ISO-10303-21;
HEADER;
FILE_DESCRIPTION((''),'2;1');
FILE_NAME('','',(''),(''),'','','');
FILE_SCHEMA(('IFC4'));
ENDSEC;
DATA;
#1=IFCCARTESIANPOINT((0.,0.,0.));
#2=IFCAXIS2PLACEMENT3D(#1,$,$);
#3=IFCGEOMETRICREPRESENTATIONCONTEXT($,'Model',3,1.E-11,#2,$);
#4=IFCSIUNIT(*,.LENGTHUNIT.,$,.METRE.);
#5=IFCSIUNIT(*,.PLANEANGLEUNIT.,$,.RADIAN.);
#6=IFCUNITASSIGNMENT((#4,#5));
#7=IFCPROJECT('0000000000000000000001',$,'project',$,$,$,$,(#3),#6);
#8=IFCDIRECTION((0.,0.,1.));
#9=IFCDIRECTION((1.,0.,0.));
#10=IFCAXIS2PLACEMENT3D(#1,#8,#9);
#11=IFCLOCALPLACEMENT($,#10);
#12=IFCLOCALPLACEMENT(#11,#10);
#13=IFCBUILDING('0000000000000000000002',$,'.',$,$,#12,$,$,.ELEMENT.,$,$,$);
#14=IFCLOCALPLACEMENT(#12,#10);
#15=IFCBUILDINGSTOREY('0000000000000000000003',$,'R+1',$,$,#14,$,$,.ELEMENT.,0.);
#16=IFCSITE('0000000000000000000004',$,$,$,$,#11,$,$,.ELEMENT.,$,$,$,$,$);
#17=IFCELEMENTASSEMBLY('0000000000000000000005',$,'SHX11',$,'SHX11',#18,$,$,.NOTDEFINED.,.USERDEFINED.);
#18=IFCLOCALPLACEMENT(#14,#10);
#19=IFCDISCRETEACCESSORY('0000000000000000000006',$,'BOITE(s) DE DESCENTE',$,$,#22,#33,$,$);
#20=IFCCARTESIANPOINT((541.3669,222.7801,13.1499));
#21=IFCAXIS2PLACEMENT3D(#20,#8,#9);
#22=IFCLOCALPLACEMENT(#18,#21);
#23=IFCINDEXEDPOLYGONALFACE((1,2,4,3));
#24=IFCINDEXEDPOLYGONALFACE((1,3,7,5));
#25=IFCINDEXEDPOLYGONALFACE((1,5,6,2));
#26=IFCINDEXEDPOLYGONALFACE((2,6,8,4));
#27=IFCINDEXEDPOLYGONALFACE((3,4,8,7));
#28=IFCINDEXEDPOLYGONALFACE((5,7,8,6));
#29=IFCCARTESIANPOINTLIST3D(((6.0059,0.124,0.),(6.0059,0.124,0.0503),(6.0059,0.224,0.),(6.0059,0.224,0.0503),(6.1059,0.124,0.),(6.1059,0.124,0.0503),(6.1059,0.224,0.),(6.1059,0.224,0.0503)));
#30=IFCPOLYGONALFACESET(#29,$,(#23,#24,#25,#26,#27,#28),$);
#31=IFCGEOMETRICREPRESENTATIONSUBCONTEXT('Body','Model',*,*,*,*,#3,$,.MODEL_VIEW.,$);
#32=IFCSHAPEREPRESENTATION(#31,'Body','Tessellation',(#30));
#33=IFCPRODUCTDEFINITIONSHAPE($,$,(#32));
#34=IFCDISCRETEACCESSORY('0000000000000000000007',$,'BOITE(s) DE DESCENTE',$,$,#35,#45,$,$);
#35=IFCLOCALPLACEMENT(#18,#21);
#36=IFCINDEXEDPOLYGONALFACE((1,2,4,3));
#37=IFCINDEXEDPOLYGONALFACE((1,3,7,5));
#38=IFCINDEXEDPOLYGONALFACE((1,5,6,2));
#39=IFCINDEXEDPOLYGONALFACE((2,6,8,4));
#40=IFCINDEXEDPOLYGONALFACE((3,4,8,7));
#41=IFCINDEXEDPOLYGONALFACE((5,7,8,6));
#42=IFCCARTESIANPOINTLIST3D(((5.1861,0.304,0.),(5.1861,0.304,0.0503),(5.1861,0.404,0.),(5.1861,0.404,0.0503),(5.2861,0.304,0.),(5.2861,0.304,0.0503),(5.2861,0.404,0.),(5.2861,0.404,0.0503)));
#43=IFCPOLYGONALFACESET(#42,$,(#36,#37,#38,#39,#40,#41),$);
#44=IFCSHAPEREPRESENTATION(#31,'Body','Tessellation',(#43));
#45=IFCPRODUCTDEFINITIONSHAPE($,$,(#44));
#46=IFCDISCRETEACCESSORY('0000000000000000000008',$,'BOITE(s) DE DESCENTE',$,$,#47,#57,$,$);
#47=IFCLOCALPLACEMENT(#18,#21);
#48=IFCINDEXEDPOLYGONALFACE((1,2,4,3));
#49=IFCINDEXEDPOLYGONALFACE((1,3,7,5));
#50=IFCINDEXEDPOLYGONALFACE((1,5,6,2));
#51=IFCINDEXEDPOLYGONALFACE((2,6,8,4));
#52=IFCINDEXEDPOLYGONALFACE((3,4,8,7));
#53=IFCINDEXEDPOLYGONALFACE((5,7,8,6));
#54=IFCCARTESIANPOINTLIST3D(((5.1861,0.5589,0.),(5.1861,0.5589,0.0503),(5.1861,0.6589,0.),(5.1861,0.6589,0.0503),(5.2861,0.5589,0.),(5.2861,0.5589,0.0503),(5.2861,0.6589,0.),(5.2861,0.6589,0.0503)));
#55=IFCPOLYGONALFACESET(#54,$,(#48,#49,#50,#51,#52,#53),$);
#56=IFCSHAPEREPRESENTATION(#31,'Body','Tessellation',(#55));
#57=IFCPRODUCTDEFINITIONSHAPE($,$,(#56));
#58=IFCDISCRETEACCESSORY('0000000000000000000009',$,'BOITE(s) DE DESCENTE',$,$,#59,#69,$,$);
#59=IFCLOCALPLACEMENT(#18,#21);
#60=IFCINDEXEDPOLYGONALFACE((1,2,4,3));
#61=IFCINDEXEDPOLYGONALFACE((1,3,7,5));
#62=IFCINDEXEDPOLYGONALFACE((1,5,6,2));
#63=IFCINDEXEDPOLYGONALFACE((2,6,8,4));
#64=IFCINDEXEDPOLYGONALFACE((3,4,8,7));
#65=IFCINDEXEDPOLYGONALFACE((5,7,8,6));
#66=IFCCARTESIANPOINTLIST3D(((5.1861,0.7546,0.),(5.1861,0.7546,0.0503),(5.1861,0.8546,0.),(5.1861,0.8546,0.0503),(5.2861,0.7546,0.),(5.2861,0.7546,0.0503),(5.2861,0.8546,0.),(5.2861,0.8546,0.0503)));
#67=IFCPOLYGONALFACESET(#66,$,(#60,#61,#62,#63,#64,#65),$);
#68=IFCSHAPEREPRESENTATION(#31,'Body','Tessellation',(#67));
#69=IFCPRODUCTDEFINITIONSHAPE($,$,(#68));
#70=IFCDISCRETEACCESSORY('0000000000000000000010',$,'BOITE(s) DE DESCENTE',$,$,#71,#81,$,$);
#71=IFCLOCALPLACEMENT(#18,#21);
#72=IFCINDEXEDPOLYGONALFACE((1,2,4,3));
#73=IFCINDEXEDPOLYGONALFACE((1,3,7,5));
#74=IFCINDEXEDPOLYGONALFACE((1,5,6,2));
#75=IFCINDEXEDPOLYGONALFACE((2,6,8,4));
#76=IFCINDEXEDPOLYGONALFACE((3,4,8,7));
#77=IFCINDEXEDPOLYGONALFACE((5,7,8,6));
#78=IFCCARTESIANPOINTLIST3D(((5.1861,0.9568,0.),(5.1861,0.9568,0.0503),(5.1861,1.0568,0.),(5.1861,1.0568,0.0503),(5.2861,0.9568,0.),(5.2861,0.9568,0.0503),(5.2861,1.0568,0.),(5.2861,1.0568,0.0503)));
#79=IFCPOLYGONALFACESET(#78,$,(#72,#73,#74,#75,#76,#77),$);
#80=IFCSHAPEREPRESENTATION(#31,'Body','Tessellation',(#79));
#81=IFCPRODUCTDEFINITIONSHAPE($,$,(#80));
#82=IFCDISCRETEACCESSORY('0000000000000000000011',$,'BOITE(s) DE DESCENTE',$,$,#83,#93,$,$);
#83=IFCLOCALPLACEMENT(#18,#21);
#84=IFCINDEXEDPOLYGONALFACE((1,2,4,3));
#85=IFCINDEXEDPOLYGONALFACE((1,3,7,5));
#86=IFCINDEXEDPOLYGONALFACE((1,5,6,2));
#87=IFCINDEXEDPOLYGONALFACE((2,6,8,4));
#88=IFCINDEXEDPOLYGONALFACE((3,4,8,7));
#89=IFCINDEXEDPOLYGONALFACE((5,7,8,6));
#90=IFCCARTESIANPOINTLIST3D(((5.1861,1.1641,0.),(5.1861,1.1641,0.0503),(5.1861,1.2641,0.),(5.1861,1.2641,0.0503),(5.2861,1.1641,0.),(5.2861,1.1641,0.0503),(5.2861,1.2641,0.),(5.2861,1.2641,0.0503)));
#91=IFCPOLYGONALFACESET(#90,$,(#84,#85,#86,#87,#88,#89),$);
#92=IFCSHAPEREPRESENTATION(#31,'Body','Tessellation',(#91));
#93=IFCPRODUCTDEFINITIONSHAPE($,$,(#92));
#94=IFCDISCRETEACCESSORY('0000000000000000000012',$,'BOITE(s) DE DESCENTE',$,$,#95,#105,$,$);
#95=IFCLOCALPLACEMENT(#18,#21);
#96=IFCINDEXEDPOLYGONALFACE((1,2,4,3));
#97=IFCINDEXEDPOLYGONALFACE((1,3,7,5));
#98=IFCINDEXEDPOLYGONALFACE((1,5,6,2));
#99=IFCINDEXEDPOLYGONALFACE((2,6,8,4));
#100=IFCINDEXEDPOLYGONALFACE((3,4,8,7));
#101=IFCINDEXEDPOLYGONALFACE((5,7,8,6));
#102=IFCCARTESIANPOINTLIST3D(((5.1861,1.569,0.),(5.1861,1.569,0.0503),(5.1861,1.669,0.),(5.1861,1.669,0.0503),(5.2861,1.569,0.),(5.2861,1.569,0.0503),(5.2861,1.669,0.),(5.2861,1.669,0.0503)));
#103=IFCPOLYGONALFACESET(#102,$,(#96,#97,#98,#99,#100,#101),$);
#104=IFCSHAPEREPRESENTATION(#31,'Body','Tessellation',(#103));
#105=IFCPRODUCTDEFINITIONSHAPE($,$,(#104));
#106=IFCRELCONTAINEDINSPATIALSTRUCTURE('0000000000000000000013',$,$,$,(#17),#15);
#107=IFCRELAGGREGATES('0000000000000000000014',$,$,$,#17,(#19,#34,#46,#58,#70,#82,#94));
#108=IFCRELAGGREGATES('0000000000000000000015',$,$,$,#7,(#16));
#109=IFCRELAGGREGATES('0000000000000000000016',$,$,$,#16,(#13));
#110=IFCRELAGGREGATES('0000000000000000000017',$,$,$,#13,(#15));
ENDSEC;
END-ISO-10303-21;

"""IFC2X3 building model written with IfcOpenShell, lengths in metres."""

from ifc_helpers import new_model, si_unit, frame, origin, origin_with_axes, place, context, subcontext, project, spatial, polyline, outline, extrude, element, aggregate, save


model = new_model("IFC2X3")

# Units and contexts
model_context = context("Model", 3, precision=1e-11, world=origin())
body_context = subcontext(model_context, "Body", "Model", "MODEL_VIEW")
ifc_project = project(units=[si_unit("LENGTHUNIT", "METRE"), si_unit("PLANEANGLEUNIT", "RADIAN")], contexts=[model_context])

# Site, building, storey
site_placement = place(None, origin_with_axes())
site = spatial("IfcSite", under=ifc_project, at=site_placement, CompositionType="ELEMENT")
building_placement = place(site_placement, origin_with_axes())
building = spatial("IfcBuilding", under=site, at=building_placement, Name=".", CompositionType="ELEMENT")
storey_placement = place(building_placement, origin_with_axes())
storey = spatial("IfcBuildingStorey", under=building, at=storey_placement, Name="R+1", CompositionType="ELEMENT", Elevation=0.0)

# Element assembly, discrete accessories
assembly_1_placement = place(storey_placement, origin_with_axes())
assembly_1 = element("IfcElementAssembly", 1, at=assembly_1_placement, inside=storey, Name="SHX11", ObjectType="SHX11", AssemblyPlace="NOTDEFINED", PredefinedType="USERDEFINED")
discrete_accessory_1_placement = place(assembly_1_placement, frame((541.3669, 222.7801, 13.1499), z_axis=(0.0, 0.0, 1.0), x_axis=(1.0, 0.0, 0.0)))
discrete_accessory_1 = element("IfcDiscreteAccessory", 2, at=discrete_accessory_1_placement, Name="BOITE(s) DE DESCENTE", context=body_context, shape_type="SweptSolid", body=[
    extrude(outline(polyline([(0.124, -6.0059), (0.124, -6.1059), (0.224, -6.1059), (0.224, -6.0059), (0.124, -6.0059)])), frame((0.0, 0.0, 0.0), z_axis=(0.0, 0.0, 1.0), x_axis=(0.0, 1.0, 0.0)), (0.0, 0.0, 1.0), 0.0503),
])
discrete_accessory_2_placement = place(assembly_1_placement, frame((541.3669, 222.7801, 13.1499), z_axis=(0.0, 0.0, 1.0), x_axis=(1.0, 0.0, 0.0)))
discrete_accessory_2 = element("IfcDiscreteAccessory", 3, at=discrete_accessory_2_placement, Name="BOITE(s) DE DESCENTE", context=body_context, shape_type="SweptSolid", body=[
    extrude(outline(polyline([(0.304, -5.1861), (0.304, -5.2861), (0.404, -5.2861), (0.404, -5.1861), (0.304, -5.1861)])), frame((0.0, 0.0, 0.0), z_axis=(0.0, 0.0, 1.0), x_axis=(0.0, 1.0, 0.0)), (0.0, 0.0, 1.0), 0.0503),
])
discrete_accessory_3_placement = place(assembly_1_placement, frame((541.3669, 222.7801, 13.1499), z_axis=(0.0, 0.0, 1.0), x_axis=(1.0, 0.0, 0.0)))
discrete_accessory_3 = element("IfcDiscreteAccessory", 4, at=discrete_accessory_3_placement, Name="BOITE(s) DE DESCENTE", context=body_context, shape_type="SweptSolid", body=[
    extrude(outline(polyline([(0.5589, -5.1861), (0.5589, -5.2861), (0.6589, -5.2861), (0.6589, -5.1861), (0.5589, -5.1861)])), frame((0.0, 0.0, 0.0), z_axis=(0.0, 0.0, 1.0), x_axis=(0.0, 1.0, 0.0)), (0.0, 0.0, 1.0), 0.0503),
])
discrete_accessory_4_placement = place(assembly_1_placement, frame((541.3669, 222.7801, 13.1499), z_axis=(0.0, 0.0, 1.0), x_axis=(1.0, 0.0, 0.0)))
discrete_accessory_4 = element("IfcDiscreteAccessory", 5, at=discrete_accessory_4_placement, Name="BOITE(s) DE DESCENTE", context=body_context, shape_type="SweptSolid", body=[
    extrude(outline(polyline([(0.7546, -5.1861), (0.7546, -5.2861), (0.8546, -5.2861), (0.8546, -5.1861), (0.7546, -5.1861)])), frame((0.0, 0.0, 0.0), z_axis=(0.0, 0.0, 1.0), x_axis=(0.0, 1.0, 0.0)), (0.0, 0.0, 1.0), 0.0503),
])
discrete_accessory_5_placement = place(assembly_1_placement, frame((541.3669, 222.7801, 13.1499), z_axis=(0.0, 0.0, 1.0), x_axis=(1.0, 0.0, 0.0)))
discrete_accessory_5 = element("IfcDiscreteAccessory", 6, at=discrete_accessory_5_placement, Name="BOITE(s) DE DESCENTE", context=body_context, shape_type="SweptSolid", body=[
    extrude(outline(polyline([(0.9568, -5.1861), (0.9568, -5.2861), (1.0568, -5.2861), (1.0568, -5.1861), (0.9568, -5.1861)])), frame((0.0, 0.0, 0.0), z_axis=(0.0, 0.0, 1.0), x_axis=(0.0, 1.0, 0.0)), (0.0, 0.0, 1.0), 0.0503),
])
discrete_accessory_6_placement = place(assembly_1_placement, frame((541.3669, 222.7801, 13.1499), z_axis=(0.0, 0.0, 1.0), x_axis=(1.0, 0.0, 0.0)))
discrete_accessory_6 = element("IfcDiscreteAccessory", 7, at=discrete_accessory_6_placement, Name="BOITE(s) DE DESCENTE", context=body_context, shape_type="SweptSolid", body=[
    extrude(outline(polyline([(1.1641, -5.1861), (1.1641, -5.2861), (1.2641, -5.2861), (1.2641, -5.1861), (1.1641, -5.1861)])), frame((0.0, 0.0, 0.0), z_axis=(0.0, 0.0, 1.0), x_axis=(0.0, 1.0, 0.0)), (0.0, 0.0, 1.0), 0.0503),
])
discrete_accessory_7_placement = place(assembly_1_placement, frame((541.3669, 222.7801, 13.1499), z_axis=(0.0, 0.0, 1.0), x_axis=(1.0, 0.0, 0.0)))
discrete_accessory_7 = element("IfcDiscreteAccessory", 8, at=discrete_accessory_7_placement, Name="BOITE(s) DE DESCENTE", context=body_context, shape_type="SweptSolid", body=[
    extrude(outline(polyline([(1.569, -5.1861), (1.569, -5.2861), (1.669, -5.2861), (1.669, -5.1861), (1.569, -5.1861)])), frame((0.0, 0.0, 0.0), z_axis=(0.0, 0.0, 1.0), x_axis=(0.0, 1.0, 0.0)), (0.0, 0.0, 1.0), 0.0503),
])
aggregate(assembly_1, [discrete_accessory_1, discrete_accessory_2, discrete_accessory_3, discrete_accessory_4, discrete_accessory_5, discrete_accessory_6, discrete_accessory_7])

save(model, "model.ifc")
